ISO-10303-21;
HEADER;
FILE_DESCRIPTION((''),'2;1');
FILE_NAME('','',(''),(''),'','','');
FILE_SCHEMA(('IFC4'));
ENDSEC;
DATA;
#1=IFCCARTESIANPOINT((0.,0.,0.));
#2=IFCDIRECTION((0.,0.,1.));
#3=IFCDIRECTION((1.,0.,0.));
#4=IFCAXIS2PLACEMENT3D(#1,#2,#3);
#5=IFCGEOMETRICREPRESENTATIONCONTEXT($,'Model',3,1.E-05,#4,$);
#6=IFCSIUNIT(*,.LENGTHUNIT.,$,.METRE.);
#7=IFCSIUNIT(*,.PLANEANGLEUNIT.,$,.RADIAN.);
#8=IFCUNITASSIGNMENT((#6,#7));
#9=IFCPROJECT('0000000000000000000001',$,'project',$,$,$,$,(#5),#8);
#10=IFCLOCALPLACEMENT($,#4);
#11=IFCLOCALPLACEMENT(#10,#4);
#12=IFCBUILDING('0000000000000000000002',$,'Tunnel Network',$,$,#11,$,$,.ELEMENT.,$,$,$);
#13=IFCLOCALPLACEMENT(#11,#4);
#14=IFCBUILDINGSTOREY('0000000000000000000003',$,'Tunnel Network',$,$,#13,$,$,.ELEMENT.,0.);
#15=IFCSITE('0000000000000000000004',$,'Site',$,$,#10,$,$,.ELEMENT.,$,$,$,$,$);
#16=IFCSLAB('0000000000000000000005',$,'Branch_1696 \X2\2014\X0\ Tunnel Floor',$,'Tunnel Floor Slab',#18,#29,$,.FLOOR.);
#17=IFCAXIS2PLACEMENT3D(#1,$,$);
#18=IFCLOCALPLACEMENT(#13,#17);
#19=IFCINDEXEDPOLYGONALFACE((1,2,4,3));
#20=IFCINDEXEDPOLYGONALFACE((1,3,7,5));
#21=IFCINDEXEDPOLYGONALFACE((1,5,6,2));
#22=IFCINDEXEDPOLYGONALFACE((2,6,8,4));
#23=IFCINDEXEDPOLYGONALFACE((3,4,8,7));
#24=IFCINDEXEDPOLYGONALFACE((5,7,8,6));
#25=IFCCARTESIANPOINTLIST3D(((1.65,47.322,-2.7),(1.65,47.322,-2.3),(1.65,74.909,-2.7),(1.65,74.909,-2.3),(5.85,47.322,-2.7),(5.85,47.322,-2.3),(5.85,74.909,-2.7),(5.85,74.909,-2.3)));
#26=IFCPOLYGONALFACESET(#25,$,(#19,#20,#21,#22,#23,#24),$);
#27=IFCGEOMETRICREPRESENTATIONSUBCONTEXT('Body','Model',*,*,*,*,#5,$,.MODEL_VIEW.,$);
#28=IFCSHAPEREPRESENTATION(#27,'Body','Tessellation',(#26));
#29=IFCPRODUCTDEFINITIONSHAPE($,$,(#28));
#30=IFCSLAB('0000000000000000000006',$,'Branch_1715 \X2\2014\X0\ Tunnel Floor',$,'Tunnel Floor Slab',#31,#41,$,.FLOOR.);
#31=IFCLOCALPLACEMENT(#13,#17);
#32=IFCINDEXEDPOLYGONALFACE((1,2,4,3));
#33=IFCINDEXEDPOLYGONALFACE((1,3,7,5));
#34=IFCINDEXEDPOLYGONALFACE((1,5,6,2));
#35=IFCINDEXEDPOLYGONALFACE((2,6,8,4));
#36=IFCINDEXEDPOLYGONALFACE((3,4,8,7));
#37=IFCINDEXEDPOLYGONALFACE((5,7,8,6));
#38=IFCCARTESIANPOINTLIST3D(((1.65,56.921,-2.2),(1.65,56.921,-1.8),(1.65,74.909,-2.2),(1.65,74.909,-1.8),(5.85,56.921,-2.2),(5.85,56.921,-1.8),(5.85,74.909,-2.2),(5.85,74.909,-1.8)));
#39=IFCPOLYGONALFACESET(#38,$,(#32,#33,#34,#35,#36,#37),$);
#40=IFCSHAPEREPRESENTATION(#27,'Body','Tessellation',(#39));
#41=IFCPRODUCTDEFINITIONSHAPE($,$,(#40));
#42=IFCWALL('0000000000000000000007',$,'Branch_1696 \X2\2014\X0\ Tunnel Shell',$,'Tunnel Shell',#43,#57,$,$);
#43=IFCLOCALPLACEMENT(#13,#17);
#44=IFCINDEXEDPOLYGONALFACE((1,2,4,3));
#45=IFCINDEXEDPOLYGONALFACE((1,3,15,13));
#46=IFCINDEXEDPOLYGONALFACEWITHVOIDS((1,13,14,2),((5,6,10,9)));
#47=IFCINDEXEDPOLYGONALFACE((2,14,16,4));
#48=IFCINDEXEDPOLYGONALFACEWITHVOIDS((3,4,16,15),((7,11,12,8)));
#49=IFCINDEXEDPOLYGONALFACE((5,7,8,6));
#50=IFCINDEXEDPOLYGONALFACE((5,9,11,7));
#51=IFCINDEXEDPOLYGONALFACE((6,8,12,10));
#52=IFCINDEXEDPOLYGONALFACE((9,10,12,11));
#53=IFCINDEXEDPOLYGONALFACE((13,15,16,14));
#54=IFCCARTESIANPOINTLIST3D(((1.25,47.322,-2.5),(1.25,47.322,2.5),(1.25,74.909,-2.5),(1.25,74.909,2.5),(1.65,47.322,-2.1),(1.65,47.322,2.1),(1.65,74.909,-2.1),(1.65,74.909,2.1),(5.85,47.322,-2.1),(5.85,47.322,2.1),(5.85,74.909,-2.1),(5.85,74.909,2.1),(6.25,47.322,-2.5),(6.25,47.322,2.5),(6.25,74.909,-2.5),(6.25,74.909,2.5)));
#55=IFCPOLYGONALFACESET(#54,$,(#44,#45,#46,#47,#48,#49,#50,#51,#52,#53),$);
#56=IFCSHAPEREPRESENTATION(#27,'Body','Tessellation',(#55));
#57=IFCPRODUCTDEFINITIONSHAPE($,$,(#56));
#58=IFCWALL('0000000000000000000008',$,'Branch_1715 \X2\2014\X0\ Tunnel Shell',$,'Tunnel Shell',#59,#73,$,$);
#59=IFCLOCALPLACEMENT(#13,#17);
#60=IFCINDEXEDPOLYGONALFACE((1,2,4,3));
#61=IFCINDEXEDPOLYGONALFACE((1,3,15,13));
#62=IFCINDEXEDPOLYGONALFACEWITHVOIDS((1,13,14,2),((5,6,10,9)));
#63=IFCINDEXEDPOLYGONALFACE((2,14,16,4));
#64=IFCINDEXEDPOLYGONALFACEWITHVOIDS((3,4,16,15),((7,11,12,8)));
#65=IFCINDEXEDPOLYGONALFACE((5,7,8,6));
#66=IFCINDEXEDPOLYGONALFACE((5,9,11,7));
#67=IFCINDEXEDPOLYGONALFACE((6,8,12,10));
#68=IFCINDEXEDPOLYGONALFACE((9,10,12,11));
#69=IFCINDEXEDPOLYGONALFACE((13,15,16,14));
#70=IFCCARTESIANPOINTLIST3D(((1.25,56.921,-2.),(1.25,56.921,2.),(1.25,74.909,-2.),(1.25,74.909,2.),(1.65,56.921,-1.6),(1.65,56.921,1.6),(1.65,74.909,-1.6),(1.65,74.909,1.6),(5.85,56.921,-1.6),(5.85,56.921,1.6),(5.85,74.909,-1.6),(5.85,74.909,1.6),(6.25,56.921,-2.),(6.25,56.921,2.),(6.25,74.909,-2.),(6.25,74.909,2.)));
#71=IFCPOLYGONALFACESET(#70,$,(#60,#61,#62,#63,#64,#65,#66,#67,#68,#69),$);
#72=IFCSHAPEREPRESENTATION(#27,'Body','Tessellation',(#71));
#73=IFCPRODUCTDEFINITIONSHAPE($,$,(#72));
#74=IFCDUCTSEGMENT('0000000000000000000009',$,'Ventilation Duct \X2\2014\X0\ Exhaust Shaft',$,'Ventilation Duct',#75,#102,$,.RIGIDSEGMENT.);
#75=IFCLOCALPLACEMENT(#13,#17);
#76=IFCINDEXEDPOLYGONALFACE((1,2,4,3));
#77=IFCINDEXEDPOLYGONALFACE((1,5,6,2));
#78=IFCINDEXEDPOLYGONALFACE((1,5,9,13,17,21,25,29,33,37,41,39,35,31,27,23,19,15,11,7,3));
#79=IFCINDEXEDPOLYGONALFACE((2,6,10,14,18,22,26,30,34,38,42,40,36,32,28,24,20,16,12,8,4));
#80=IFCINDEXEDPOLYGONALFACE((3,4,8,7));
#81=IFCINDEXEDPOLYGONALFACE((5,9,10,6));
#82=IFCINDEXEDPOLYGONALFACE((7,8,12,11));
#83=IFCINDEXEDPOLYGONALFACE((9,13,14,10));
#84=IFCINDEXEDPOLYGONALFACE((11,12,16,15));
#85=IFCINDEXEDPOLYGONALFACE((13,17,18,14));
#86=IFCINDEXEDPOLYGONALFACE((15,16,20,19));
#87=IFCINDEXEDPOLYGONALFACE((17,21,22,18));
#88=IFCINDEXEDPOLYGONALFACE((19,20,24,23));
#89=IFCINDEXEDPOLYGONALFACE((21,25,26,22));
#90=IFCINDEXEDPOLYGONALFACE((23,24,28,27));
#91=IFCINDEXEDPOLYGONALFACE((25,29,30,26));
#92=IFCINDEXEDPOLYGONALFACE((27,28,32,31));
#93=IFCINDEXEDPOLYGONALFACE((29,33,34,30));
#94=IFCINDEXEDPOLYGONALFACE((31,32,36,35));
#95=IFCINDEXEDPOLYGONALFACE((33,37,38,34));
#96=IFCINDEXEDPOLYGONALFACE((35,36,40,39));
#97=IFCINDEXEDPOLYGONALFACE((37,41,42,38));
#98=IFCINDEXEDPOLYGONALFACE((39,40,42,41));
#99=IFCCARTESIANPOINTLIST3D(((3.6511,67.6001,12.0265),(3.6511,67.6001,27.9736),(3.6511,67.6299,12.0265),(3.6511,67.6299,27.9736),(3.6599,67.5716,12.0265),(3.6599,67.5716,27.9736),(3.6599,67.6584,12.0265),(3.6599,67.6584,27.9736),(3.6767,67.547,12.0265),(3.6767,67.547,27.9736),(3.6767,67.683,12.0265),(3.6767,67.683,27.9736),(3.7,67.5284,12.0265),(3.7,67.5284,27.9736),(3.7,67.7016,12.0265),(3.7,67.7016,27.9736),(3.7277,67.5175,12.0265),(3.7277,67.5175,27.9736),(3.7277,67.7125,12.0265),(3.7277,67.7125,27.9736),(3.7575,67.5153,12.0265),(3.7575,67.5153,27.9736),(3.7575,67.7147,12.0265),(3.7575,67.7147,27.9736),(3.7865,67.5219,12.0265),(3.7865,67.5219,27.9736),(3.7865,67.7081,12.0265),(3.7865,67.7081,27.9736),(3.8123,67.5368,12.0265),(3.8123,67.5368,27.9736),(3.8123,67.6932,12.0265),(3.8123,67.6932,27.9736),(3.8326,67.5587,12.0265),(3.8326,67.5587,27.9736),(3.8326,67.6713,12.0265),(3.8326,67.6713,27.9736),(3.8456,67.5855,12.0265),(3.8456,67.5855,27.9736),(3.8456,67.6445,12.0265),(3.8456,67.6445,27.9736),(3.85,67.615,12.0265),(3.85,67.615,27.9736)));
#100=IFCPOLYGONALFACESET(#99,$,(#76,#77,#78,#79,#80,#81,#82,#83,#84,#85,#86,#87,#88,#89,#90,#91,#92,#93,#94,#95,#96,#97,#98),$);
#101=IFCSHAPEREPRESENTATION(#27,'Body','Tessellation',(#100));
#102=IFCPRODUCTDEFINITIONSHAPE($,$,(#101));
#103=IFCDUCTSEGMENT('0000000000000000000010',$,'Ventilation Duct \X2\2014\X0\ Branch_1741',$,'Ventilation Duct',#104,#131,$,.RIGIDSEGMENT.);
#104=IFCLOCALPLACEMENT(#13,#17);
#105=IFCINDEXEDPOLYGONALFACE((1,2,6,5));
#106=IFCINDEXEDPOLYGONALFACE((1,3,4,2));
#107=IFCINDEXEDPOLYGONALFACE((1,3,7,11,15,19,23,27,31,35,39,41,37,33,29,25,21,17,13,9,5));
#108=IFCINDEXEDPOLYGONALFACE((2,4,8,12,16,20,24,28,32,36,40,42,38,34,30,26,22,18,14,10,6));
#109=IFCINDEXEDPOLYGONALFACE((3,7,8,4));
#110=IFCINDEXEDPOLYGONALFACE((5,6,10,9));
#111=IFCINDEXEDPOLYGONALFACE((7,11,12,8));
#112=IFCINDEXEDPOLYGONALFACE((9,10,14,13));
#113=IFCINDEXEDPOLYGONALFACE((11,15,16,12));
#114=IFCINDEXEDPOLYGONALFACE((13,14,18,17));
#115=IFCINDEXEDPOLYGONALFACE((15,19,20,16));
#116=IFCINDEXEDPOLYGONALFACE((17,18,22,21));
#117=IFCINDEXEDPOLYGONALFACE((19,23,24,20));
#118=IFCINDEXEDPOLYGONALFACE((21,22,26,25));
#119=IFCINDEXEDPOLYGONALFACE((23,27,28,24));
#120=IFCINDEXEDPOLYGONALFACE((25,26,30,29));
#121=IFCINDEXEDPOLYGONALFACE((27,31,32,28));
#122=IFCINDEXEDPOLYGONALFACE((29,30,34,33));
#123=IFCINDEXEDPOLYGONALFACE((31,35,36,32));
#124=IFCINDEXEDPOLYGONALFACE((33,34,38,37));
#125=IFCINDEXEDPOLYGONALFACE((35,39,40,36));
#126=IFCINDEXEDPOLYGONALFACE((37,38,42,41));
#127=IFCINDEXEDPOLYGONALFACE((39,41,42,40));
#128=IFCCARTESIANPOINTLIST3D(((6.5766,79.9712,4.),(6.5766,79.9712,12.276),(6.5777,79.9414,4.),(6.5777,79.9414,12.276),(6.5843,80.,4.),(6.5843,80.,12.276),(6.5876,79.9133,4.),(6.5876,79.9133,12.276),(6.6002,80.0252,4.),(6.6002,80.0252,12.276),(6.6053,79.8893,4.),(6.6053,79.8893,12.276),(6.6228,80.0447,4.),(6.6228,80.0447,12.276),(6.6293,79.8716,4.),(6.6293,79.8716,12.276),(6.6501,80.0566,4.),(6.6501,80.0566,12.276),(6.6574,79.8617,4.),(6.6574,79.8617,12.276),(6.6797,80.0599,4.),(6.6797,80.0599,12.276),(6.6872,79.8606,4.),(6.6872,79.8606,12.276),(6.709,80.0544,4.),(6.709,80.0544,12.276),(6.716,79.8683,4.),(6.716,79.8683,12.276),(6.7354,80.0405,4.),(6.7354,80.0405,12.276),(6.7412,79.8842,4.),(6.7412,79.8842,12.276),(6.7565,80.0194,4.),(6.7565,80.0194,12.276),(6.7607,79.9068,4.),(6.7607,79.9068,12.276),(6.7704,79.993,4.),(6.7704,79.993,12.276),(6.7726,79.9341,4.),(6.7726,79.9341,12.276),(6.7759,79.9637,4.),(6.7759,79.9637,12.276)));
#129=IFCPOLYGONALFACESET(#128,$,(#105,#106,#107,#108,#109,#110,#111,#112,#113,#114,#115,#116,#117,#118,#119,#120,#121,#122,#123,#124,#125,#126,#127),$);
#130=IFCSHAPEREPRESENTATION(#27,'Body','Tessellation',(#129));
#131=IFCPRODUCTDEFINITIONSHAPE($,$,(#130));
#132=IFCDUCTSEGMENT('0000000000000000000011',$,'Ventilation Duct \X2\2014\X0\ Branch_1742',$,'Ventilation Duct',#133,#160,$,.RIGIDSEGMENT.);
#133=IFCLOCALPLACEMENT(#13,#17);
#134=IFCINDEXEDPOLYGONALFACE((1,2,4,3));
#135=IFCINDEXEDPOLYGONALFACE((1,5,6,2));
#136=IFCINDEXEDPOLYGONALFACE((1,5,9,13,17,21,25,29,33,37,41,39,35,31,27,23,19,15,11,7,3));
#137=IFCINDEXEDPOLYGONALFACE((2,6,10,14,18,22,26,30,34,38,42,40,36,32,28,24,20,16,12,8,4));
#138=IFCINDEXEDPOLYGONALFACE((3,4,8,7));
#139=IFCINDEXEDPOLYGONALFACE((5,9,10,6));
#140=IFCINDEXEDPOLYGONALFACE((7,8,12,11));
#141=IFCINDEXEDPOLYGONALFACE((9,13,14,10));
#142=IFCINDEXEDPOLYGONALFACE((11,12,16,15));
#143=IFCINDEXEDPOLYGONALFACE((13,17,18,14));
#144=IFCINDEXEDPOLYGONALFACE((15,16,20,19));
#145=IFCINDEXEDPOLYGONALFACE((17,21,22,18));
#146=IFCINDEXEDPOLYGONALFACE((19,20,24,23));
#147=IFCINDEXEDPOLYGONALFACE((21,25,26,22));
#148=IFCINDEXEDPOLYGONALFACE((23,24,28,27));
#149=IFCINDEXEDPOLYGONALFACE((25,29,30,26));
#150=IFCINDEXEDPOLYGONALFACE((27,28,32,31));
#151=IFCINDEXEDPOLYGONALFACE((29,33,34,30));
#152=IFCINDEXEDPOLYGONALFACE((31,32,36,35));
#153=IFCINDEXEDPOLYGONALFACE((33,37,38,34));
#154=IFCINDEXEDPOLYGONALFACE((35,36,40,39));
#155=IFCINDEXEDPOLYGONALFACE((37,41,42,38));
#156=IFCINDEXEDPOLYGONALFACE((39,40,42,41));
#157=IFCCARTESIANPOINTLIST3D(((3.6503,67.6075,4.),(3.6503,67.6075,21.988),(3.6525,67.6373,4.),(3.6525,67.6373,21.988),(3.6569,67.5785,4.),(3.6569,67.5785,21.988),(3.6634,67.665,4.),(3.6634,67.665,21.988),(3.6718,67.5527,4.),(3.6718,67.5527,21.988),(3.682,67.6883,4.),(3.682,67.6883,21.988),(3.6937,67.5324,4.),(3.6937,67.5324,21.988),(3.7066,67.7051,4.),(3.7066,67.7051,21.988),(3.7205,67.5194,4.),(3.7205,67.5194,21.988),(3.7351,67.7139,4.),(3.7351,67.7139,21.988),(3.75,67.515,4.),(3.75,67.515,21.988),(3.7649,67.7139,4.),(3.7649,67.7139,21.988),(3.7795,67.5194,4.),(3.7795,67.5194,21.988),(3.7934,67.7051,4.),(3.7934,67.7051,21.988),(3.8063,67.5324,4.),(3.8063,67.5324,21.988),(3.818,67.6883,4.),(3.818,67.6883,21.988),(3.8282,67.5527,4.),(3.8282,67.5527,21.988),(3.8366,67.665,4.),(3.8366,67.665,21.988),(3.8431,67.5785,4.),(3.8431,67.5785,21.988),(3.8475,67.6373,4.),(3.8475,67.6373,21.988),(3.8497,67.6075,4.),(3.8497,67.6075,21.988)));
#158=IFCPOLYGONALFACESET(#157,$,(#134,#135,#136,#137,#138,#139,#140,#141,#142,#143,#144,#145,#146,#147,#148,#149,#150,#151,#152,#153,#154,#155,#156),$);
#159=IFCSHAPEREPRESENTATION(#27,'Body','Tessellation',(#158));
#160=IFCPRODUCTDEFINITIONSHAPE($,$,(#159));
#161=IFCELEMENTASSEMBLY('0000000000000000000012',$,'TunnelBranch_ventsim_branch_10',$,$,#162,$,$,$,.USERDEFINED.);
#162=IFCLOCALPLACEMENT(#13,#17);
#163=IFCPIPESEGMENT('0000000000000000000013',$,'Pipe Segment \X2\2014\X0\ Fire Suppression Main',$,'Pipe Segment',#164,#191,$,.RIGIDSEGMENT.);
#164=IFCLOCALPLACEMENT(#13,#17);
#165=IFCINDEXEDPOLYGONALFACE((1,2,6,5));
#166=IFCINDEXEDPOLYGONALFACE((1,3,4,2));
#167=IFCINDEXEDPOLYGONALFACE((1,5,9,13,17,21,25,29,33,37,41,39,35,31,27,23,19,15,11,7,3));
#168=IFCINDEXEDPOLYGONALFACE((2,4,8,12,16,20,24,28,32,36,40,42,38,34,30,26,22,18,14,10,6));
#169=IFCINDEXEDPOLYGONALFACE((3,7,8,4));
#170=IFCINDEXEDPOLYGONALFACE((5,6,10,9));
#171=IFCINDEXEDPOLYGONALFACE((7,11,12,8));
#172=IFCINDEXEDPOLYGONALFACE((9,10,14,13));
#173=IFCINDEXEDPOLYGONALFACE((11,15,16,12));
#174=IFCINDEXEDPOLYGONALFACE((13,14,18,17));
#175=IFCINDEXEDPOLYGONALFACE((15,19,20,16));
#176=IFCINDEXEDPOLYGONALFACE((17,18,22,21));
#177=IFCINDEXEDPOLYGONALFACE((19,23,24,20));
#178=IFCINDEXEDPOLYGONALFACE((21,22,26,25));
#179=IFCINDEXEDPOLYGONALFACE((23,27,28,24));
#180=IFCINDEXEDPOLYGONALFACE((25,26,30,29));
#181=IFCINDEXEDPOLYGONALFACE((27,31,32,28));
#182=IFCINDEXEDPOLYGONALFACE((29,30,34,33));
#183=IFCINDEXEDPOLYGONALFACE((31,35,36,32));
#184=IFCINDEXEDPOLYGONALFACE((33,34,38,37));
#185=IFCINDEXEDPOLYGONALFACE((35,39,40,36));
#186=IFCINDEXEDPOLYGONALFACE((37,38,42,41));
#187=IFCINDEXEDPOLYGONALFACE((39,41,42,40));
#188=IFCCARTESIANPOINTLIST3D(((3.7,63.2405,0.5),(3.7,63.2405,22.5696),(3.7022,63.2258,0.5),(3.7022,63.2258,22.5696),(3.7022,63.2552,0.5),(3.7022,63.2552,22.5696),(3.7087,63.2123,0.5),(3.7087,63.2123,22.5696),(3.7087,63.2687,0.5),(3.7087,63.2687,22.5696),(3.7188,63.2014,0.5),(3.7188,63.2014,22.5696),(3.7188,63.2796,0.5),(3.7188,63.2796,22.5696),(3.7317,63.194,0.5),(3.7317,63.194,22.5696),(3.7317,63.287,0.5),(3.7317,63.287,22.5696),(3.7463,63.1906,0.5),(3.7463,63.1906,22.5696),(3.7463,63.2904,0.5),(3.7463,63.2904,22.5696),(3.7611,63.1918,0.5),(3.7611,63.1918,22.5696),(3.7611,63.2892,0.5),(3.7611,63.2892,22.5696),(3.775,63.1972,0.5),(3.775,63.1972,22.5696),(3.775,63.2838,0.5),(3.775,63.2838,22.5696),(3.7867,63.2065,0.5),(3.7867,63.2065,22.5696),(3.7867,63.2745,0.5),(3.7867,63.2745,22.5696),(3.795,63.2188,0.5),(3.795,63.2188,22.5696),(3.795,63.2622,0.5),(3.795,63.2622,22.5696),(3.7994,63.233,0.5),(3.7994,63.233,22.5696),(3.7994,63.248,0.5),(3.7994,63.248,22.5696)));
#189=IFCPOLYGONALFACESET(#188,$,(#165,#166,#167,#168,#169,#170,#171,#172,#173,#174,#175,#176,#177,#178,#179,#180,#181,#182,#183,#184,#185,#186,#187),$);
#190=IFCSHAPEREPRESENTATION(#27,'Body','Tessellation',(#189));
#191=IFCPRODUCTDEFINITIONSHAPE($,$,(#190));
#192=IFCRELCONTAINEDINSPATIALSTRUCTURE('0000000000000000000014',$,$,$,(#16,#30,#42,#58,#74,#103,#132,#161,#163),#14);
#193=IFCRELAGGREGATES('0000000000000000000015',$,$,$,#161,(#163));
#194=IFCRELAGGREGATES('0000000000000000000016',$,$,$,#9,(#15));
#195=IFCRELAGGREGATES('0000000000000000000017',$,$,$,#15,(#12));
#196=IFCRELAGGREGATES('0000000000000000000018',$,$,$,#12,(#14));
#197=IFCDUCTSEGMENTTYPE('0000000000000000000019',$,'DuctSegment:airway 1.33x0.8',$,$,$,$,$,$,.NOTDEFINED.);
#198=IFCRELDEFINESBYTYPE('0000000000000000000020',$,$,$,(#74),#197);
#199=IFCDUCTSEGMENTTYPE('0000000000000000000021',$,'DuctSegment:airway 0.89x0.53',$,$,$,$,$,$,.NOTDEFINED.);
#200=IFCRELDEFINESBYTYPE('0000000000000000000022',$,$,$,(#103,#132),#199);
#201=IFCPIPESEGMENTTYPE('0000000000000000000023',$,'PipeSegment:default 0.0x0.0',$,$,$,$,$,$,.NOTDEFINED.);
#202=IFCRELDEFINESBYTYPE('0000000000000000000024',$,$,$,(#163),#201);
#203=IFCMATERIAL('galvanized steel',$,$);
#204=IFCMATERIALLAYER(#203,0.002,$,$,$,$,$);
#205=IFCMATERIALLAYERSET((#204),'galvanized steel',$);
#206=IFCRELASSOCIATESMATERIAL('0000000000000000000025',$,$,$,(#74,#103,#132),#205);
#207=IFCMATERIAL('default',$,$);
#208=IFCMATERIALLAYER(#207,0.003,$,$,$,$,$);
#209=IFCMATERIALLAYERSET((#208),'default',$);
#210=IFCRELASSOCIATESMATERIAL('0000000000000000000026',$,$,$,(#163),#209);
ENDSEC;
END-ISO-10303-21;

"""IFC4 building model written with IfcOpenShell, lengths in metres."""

from ifc_helpers import new_model, entity, si_unit, frame, origin_with_axes, origin_2d_with_axis, place, context, subcontext, project, spatial, rectangle, hollow_rectangle, circle, extrude, material, layer, layer_set, layer_usage, type_object, element, aggregate, save


model = new_model("IFC4")

# Units and contexts
model_context = context("Model", 3, precision=1e-05, world=origin_with_axes())
body_context = subcontext(model_context, "Body", "Model", "MODEL_VIEW")
ifc_project = project(units=[si_unit("LENGTHUNIT", "METRE"), si_unit("PLANEANGLEUNIT", "RADIAN")], contexts=[model_context])

# Site, building, storey
site_placement = place(None, origin_with_axes())
site = spatial("IfcSite", under=ifc_project, at=site_placement, Name="Site", CompositionType="ELEMENT")
building_placement = place(site_placement, origin_with_axes())
building = spatial("IfcBuilding", under=site, at=building_placement, Name="Tunnel Network", CompositionType="ELEMENT")
storey_placement = place(building_placement, origin_with_axes())
storey = spatial("IfcBuildingStorey", under=building, at=storey_placement, Name="Tunnel Network", CompositionType="ELEMENT", Elevation=0.0)

# Slabs
placement_1 = place(storey_placement, frame((3.75, 74.909, 0.0), z_axis=(0.0, 0.0, 1.0), x_axis=(0.0, -1.0, 0.0)))
element("IfcSlab", 1, at=placement_1, inside=storey, Name="Branch_1696 — Tunnel Floor", ObjectType="Tunnel Floor Slab", PredefinedType="FLOOR", context=body_context, shape_type="SweptSolid", body=[
    extrude(rectangle(XDim=0.4, YDim=4.2, at=origin_2d_with_axis()), frame((0.0, 0.0, -2.5), z_axis=(1.0, 0.0, 0.0), x_axis=(0.0, 0.0, 1.0)), (0.0, 0.0, 1.0), 27.587),
])
placement_2 = place(storey_placement, frame((3.75, 74.909, 0.0), z_axis=(0.0, 0.0, 1.0), x_axis=(0.0, -1.0, 0.0)))
element("IfcSlab", 2, at=placement_2, inside=storey, Name="Branch_1715 — Tunnel Floor", ObjectType="Tunnel Floor Slab", PredefinedType="FLOOR", context=body_context, shape_type="SweptSolid", body=[
    extrude(rectangle(XDim=0.4, YDim=4.2, at=origin_2d_with_axis()), frame((0.0, 0.0, -2.0), z_axis=(1.0, 0.0, 0.0), x_axis=(0.0, 0.0, 1.0)), (0.0, 0.0, 1.0), 17.988),
])

# Walls
element("IfcWall", 3, at=placement_1, inside=storey, Name="Branch_1696 — Tunnel Shell", ObjectType="Tunnel Shell", context=body_context, shape_type="SweptSolid", body=[
    extrude(hollow_rectangle(XDim=5.0, YDim=5.0, WallThickness=0.4, at=origin_2d_with_axis()), frame((0.0, 0.0, 0.0), z_axis=(1.0, 0.0, 0.0), x_axis=(0.0, 0.0, 1.0)), (0.0, 0.0, 1.0), 27.587),
])
element("IfcWall", 4, at=placement_2, inside=storey, Name="Branch_1715 — Tunnel Shell", ObjectType="Tunnel Shell", context=body_context, shape_type="SweptSolid", body=[
    extrude(hollow_rectangle(XDim=4.0, YDim=5.0, WallThickness=0.4, at=origin_2d_with_axis()), frame((0.0, 0.0, 0.0), z_axis=(1.0, 0.0, 0.0), x_axis=(0.0, 0.0, 1.0)), (0.0, 0.0, 1.0), 17.988),
])

# Duct segments
ifc_material_1 = material(Name="galvanized steel")
ifc_layer_1 = layer(ifc_material_1, 0.002)
ifc_layer_set_1 = layer_set([ifc_layer_1], Name="galvanized steel")
ifc_layer_usage_1 = layer_usage(ifc_layer_set_1, "AXIS2", "POSITIVE", 0.0)
duct_segment_type_1 = type_object("IfcDuctSegmentType", Name="DuctSegment:airway 1.33x0.8")
duct_segment_1_placement = place(storey_placement, frame((3.75, 67.615, 12.0265), z_axis=(0.0, 0.0, 1.0), x_axis=(1.0, 0.0, 0.0)))
element("IfcDuctSegment", 5, at=duct_segment_1_placement, inside=storey, type_object=duct_segment_type_1, material=ifc_layer_usage_1, Name="Ventilation Duct — Exhaust Shaft", ObjectType="Ventilation Duct", PredefinedType="RIGIDSEGMENT", context=body_context, shape_type="AdvancedSweptSolid", body=[
    entity("IfcSweptDiskSolid", entity("IfcPolyline", [entity("IfcCartesianPoint", [0.0, 0.0, 0.0]), entity("IfcCartesianPoint", [0.0, 0.0, 15.9471])]), 0.1),
])
ifc_layer_usage_2 = layer_usage(ifc_layer_set_1, "AXIS2", "POSITIVE", 0.0)
duct_segment_type_2 = type_object("IfcDuctSegmentType", Name="DuctSegment:airway 0.89x0.53")
duct_segment_2_placement = place(storey_placement, frame((6.676, 79.96, 4.0), z_axis=(0.0, 0.0, 1.0), x_axis=(-0.707107, -0.707106, 0.0)))
element("IfcDuctSegment", 6, at=duct_segment_2_placement, inside=storey, type_object=duct_segment_type_2, material=ifc_layer_usage_2, Name="Ventilation Duct — Branch_1741", ObjectType="Ventilation Duct", PredefinedType="RIGIDSEGMENT", context=body_context, shape_type="AdvancedSweptSolid", body=[
    entity("IfcSweptDiskSolid", entity("IfcPolyline", [entity("IfcCartesianPoint", [0.0, 0.0, 0.0]), entity("IfcCartesianPoint", [0.0, 0.0, 8.276])]), 0.1),
])
ifc_layer_usage_3 = layer_usage(ifc_layer_set_1, "AXIS2", "POSITIVE", 0.0)
duct_segment_3_placement = place(storey_placement, frame((3.75, 67.615, 4.0), z_axis=(0.0, 0.0, 1.0), x_axis=(0.0, -1.0, 0.0)))
element("IfcDuctSegment", 7, at=duct_segment_3_placement, inside=storey, type_object=duct_segment_type_2, material=ifc_layer_usage_3, Name="Ventilation Duct — Branch_1742", ObjectType="Ventilation Duct", PredefinedType="RIGIDSEGMENT", context=body_context, shape_type="AdvancedSweptSolid", body=[
    entity("IfcSweptDiskSolid", entity("IfcPolyline", [entity("IfcCartesianPoint", [0.0, 0.0, 0.0]), entity("IfcCartesianPoint", [0.0, 0.0, 17.988])]), 0.1),
])

# Element assembly, pipe segment
assembly_1_placement = place(storey_placement, frame((3.75, 63.2405, 1.25), z_axis=(0.0, 1.0, 0.0), x_axis=(-1.0, 0.0, 0.0)))
assembly_1 = element("IfcElementAssembly", 8, at=assembly_1_placement, inside=storey, Name="TunnelBranch_ventsim_branch_10", PredefinedType="USERDEFINED")
ifc_material_2 = material(Name="default")
ifc_layer_2 = layer(ifc_material_2, 0.003)
ifc_layer_set_2 = layer_set([ifc_layer_2], Name="default")
ifc_layer_usage_4 = layer_usage(ifc_layer_set_2, "AXIS2", "POSITIVE", 0.0)
pipe_segment_type = type_object("IfcPipeSegmentType", Name="PipeSegment:default 0.0x0.0")
pipe_segment_1_placement = place(storey_placement, frame((3.75, 63.2405, 0.5), z_axis=(0.0, 0.0, 1.0), x_axis=(-1.0, 0.0, 0.0)))
pipe_segment_1 = element("IfcPipeSegment", 9, at=pipe_segment_1_placement, inside=storey, type_object=pipe_segment_type, material=ifc_layer_usage_4, Name="Pipe Segment — Fire Suppression Main", ObjectType="Pipe Segment", PredefinedType="RIGIDSEGMENT", context=body_context, shape_type="SweptSolid", body=[
    extrude(circle(Radius=0.05, at=origin_2d_with_axis()), origin_with_axes(), (0.0, 0.0, 1.0), 22.0696),
])

aggregate(assembly_1, [pipe_segment_1])

save(model, "model.ifc")
